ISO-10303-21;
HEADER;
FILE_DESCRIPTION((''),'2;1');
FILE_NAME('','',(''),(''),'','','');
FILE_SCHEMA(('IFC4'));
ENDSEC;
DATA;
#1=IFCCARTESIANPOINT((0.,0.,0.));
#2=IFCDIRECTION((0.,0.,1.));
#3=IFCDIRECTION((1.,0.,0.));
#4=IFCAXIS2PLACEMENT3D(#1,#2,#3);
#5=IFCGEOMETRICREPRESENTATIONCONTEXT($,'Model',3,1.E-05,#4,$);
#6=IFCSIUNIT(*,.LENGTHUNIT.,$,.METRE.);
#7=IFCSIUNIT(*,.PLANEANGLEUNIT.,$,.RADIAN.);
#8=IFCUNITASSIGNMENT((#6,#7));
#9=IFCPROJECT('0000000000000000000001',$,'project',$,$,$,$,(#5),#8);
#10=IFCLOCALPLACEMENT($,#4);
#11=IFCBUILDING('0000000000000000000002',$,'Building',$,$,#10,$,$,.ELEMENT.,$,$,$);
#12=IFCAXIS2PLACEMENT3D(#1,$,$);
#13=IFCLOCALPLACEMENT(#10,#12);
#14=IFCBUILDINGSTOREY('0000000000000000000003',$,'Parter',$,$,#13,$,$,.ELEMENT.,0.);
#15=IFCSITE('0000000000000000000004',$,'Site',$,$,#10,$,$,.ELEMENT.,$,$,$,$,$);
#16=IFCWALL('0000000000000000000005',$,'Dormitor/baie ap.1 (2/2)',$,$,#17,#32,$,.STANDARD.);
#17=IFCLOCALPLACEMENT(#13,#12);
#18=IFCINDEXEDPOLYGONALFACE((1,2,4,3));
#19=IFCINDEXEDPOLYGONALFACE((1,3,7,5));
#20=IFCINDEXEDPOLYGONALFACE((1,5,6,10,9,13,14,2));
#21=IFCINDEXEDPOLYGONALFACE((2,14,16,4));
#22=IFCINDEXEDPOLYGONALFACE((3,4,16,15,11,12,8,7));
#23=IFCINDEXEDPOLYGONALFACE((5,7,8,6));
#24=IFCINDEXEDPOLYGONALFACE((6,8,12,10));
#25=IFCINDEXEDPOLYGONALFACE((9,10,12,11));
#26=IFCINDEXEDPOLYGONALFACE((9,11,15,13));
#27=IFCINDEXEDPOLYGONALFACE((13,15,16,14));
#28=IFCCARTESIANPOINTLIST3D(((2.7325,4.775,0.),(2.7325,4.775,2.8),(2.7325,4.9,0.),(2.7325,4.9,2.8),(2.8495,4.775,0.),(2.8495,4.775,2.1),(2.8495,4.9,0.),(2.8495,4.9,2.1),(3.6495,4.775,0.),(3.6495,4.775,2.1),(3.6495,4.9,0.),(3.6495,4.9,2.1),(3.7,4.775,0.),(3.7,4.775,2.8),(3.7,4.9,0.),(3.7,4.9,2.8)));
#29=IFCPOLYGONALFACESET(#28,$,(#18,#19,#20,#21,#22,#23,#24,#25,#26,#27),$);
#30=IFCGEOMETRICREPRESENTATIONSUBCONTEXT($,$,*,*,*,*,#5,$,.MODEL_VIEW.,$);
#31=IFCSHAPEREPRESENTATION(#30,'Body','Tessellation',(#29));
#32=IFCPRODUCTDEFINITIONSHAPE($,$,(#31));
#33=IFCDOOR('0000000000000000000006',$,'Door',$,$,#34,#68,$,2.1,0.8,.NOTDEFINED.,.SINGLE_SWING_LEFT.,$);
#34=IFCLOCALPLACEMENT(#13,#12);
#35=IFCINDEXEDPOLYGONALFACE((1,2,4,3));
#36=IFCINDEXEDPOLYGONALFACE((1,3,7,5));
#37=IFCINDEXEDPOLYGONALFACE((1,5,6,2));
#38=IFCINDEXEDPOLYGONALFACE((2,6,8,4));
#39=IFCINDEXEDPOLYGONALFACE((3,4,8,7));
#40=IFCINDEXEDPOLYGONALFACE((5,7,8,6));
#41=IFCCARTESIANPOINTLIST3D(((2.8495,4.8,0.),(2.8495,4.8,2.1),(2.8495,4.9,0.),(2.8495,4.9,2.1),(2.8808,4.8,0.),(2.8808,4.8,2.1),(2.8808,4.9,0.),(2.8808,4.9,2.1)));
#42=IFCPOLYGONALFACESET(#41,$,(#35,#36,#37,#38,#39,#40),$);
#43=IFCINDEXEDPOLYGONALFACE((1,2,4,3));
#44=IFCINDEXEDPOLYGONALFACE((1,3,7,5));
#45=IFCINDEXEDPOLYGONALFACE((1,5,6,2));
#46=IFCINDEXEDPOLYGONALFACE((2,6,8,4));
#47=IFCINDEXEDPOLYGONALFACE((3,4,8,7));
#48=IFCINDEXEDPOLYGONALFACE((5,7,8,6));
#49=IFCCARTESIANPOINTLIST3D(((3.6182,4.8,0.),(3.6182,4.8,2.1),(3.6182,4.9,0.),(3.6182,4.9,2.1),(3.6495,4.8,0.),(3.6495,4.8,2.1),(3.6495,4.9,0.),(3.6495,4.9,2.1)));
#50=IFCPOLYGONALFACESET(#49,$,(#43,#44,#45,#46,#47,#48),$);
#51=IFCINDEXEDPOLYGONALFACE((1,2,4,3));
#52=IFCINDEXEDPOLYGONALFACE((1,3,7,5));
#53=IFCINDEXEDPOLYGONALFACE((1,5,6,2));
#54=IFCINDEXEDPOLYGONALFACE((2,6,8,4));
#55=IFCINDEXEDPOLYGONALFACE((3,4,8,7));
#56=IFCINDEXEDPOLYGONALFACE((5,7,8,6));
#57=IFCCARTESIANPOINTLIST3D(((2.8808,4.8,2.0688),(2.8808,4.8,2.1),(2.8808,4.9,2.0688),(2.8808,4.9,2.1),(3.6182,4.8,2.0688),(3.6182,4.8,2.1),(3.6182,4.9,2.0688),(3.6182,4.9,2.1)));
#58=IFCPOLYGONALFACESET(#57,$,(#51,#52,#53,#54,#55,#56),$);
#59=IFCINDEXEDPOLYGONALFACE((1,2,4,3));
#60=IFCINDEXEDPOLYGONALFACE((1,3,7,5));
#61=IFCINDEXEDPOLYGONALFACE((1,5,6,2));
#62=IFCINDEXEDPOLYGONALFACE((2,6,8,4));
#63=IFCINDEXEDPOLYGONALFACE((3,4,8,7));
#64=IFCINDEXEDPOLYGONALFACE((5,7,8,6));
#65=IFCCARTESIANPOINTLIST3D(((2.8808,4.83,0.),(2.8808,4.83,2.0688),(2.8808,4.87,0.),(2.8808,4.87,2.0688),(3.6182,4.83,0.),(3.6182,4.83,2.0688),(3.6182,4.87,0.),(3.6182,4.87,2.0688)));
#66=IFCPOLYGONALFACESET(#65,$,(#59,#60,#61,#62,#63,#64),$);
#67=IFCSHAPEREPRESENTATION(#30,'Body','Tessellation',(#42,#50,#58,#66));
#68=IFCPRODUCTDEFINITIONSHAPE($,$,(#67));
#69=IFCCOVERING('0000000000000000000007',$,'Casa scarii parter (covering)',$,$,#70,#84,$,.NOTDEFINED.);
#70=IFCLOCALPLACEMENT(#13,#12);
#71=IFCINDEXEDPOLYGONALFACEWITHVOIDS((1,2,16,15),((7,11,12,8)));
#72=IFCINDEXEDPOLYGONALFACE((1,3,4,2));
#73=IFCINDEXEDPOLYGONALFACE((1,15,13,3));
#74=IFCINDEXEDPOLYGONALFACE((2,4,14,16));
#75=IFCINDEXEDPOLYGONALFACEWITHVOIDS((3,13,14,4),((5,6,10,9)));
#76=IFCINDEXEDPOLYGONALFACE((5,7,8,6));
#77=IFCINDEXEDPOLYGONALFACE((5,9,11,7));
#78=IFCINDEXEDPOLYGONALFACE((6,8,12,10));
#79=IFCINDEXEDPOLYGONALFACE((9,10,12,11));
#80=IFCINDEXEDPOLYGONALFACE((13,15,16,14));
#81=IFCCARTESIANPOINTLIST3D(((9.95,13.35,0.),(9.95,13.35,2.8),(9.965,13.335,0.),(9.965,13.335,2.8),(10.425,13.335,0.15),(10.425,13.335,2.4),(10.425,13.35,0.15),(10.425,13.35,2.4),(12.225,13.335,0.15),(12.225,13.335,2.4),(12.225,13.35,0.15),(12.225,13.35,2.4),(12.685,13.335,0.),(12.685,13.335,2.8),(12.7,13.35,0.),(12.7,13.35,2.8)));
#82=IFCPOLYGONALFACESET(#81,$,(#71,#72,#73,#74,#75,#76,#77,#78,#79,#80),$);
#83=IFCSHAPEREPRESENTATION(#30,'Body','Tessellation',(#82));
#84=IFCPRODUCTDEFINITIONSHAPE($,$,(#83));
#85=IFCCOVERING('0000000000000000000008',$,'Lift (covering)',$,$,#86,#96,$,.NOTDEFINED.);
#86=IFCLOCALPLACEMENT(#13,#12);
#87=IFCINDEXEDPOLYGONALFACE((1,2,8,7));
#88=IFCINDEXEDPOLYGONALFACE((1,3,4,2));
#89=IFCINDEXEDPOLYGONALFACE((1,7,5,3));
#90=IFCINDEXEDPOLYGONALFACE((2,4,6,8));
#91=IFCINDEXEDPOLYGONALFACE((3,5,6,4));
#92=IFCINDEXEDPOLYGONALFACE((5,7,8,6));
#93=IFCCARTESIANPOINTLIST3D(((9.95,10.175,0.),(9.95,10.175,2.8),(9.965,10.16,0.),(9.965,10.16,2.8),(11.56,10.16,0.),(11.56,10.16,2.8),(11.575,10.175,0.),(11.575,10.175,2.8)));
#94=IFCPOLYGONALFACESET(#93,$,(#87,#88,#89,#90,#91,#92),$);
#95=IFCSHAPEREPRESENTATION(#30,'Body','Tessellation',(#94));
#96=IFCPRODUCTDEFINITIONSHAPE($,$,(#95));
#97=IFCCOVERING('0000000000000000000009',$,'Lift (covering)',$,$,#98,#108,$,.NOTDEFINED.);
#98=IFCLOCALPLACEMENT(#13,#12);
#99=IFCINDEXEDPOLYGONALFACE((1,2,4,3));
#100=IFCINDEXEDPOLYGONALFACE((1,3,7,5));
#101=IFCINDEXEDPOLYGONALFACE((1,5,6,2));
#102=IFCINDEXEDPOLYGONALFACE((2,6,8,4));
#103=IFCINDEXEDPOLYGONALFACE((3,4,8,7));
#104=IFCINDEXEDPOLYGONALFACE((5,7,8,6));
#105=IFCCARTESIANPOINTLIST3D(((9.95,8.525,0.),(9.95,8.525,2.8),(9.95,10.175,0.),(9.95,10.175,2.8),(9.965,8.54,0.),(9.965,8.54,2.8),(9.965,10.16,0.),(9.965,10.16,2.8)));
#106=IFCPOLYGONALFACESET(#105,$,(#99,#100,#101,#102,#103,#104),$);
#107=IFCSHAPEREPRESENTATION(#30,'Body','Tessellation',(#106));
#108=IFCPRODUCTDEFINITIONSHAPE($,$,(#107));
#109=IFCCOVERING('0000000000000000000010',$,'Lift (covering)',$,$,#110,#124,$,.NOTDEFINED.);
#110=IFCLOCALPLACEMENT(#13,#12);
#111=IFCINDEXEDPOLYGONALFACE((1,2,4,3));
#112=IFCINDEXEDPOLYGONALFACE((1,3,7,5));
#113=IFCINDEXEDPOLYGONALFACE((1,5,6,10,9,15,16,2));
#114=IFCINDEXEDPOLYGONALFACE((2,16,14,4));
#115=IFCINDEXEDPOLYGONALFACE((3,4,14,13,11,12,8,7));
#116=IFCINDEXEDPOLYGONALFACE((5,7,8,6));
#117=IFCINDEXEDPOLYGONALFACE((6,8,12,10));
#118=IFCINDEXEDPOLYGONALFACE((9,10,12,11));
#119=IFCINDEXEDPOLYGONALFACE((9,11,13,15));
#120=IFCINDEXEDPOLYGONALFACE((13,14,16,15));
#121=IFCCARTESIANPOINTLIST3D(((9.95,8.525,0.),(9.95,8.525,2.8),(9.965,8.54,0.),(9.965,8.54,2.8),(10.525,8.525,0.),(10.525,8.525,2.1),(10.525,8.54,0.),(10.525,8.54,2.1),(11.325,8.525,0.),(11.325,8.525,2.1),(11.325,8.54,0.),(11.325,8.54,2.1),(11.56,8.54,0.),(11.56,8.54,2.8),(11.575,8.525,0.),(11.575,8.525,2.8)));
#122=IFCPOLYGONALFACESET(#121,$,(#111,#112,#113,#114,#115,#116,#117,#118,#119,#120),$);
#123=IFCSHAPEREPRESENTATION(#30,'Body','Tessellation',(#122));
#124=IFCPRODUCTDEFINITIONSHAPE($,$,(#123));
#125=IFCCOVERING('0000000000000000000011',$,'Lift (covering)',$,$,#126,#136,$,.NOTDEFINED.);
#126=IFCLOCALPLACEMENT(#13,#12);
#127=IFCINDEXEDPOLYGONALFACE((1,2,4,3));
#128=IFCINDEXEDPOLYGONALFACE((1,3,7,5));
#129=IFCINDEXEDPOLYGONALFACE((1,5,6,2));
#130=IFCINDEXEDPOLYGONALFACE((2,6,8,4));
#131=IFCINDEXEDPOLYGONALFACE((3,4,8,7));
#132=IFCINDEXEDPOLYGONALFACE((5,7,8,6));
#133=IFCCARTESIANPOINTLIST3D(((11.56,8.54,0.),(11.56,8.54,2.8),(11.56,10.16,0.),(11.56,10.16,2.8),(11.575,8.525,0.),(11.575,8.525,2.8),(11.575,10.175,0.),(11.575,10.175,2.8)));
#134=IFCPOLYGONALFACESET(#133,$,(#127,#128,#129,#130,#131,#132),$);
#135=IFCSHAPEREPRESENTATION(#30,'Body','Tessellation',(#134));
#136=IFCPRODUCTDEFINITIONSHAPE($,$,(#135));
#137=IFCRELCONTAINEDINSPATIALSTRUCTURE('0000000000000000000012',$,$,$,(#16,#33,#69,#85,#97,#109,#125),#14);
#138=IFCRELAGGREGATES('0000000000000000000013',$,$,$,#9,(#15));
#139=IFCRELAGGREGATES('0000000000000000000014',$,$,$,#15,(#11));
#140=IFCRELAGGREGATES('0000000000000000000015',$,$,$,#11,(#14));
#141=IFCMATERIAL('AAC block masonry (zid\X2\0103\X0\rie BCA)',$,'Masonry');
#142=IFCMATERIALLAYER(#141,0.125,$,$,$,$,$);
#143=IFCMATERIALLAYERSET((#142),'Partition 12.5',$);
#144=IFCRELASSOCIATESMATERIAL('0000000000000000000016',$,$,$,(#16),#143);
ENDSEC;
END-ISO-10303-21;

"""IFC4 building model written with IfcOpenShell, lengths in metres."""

from ifc_helpers import new_model, si_unit, frame, frame_2d, origin, origin_with_axes, origin_2d, place, context, subcontext, project, spatial, polyline, rectangle, outline, extrude, material, layer, layer_set, layer_usage, element, fill, save


model = new_model("IFC4")

# Units and contexts
model_context = context("Model", 3, precision=1e-05, world=origin_with_axes())
sub_context = subcontext(model_context, None, None, "MODEL_VIEW")
ifc_project = project(units=[si_unit("LENGTHUNIT", "METRE"), si_unit("PLANEANGLEUNIT", "RADIAN")], contexts=[model_context])

# Site, building, storey
placement = place(None, origin_with_axes())
site = spatial("IfcSite", under=ifc_project, at=placement, Name="Site", CompositionType="ELEMENT")
building = spatial("IfcBuilding", under=site, at=placement, Name="Building", CompositionType="ELEMENT")
storey_placement = place(placement, origin())
storey = spatial("IfcBuildingStorey", under=building, at=storey_placement, Name="Parter", CompositionType="ELEMENT", Elevation=0.0)

# Shared definitions
ifc_material_1 = material(Name="AAC block masonry (zidărie BCA)", Category="Masonry")
ifc_layer_1 = layer(ifc_material_1, 0.125)
ifc_layer_set_1 = layer_set([ifc_layer_1], Name="Partition 12.5")
ifc_layer_usage_1 = layer_usage(ifc_layer_set_1, "AXIS2", "POSITIVE", -0.0625)

# Wall, opening, door
wall_1_placement = place(storey_placement, frame((2.7325, 4.8375, 0.0), x_axis=(1.0, 0.0, 0.0)))
wall_1 = element("IfcWall", 1, at=wall_1_placement, inside=storey, material=ifc_layer_usage_1, Name="Dormitor/baie ap.1 (2/2)", PredefinedType="STANDARD", context=sub_context, shape_type="SweptSolid", body=[
    extrude(rectangle(XDim=0.9675, YDim=0.125, at=frame_2d((0.4838, 0.0))), origin(), (0.0, 0.0, 1.0), 2.8),
])
opening_1_placement = place(wall_1_placement, frame((0.517, 0.1125, 0.0), z_axis=(0.0, -1.0, 0.0), x_axis=(1.0, 0.0, 0.0)))
opening_1 = element("IfcOpeningElement", 2, at=opening_1_placement, cuts=wall_1, PredefinedType="OPENING", context=sub_context, shape_type="SweptSolid", body=[
    extrude(rectangle(XDim=0.8, YDim=2.1, at=frame_2d((0.0, 1.05))), origin(), (0.0, 0.0, 1.0), 0.225),
])
door_placement = place(wall_1_placement, frame((0.517, 0.0625, 0.0), z_axis=(0.0, -1.0, 0.0), x_axis=(1.0, 0.0, 0.0)))
door = element("IfcDoor", 3, at=door_placement, inside=storey, Name="Door", OperationType="SINGLE_SWING_LEFT", OverallHeight=2.1, OverallWidth=0.8, PredefinedType="NOTDEFINED", context=sub_context, shape_type="SweptSolid", body=[
    extrude(rectangle(XDim=0.0312, YDim=2.1, at=origin_2d()), frame((-0.3844, 1.05, 0.0)), (0.0, 0.0, 1.0), 0.1),
    extrude(rectangle(XDim=0.0312, YDim=2.1, at=origin_2d()), frame((0.3844, 1.05, 0.0)), (0.0, 0.0, 1.0), 0.1),
    extrude(rectangle(XDim=0.7375, YDim=0.0312, at=origin_2d()), frame((0.0, 2.0844, 0.0)), (0.0, 0.0, 1.0), 0.1),
    extrude(rectangle(XDim=0.7375, YDim=2.0688, at=origin_2d()), frame((0.0, 1.0344, 0.03)), (0.0, 0.0, 1.0), 0.04),
])
fill(opening_1, door)

# Covering, opening
covering_1_placement = place(storey_placement, origin_with_axes())
covering_1 = element("IfcCovering", 4, at=covering_1_placement, inside=storey, Name="Casa scarii parter (covering)", PredefinedType="NOTDEFINED", context=sub_context, shape_type="SweptSolid", body=[
    extrude(outline(polyline([(12.7, 13.35), (9.95, 13.35), (9.965, 13.335), (12.685, 13.335), (12.7, 13.35)])), origin(), (0.0, 0.0, 1.0), 2.8),
])
opening_2_placement = place(covering_1_placement, frame((11.325, 13.665, 0.15), z_axis=(0.0, -1.0, 0.0), x_axis=(1.0, 0.0, 0.0)))
element("IfcOpeningElement", 5, at=opening_2_placement, cuts=covering_1, PredefinedType="OPENING", context=sub_context, shape_type="SweptSolid", body=[
    extrude(rectangle(XDim=1.8, YDim=2.25, at=origin_2d()), frame((0.0, 1.125, 0.0)), (0.0, 0.0, 1.0), 0.38),
])

# Coverings
covering_2_placement = place(storey_placement, origin_with_axes())
element("IfcCovering", 6, at=covering_2_placement, inside=storey, Name="Lift (covering)", PredefinedType="NOTDEFINED", context=sub_context, shape_type="SweptSolid", body=[
    extrude(outline(polyline([(11.575, 10.175), (9.95, 10.175), (9.965, 10.16), (11.56, 10.16), (11.575, 10.175)])), origin(), (0.0, 0.0, 1.0), 2.8),
])
covering_3_placement = place(storey_placement, origin_with_axes())
element("IfcCovering", 7, at=covering_3_placement, inside=storey, Name="Lift (covering)", PredefinedType="NOTDEFINED", context=sub_context, shape_type="SweptSolid", body=[
    extrude(outline(polyline([(9.95, 10.175), (9.95, 8.525), (9.965, 8.54), (9.965, 10.16), (9.95, 10.175)])), origin(), (0.0, 0.0, 1.0), 2.8),
])

# Covering, opening
covering_4_placement = place(storey_placement, origin_with_axes())
covering_4 = element("IfcCovering", 8, at=covering_4_placement, inside=storey, Name="Lift (covering)", PredefinedType="NOTDEFINED", context=sub_context, shape_type="SweptSolid", body=[
    extrude(outline(polyline([(9.95, 8.525), (11.575, 8.525), (11.56, 8.54), (9.965, 8.54), (9.95, 8.525)])), origin(), (0.0, 0.0, 1.0), 2.8),
])
opening_3_placement = place(covering_4_placement, frame((10.925, 8.59, 0.0), z_axis=(0.0, -1.0, 0.0), x_axis=(1.0, 0.0, 0.0)))
element("IfcOpeningElement", 9, at=opening_3_placement, cuts=covering_4, PredefinedType="OPENING", context=sub_context, shape_type="SweptSolid", body=[
    extrude(rectangle(XDim=0.8, YDim=2.1, at=origin_2d()), frame((0.0, 1.05, 0.0)), (0.0, 0.0, 1.0), 0.38),
])

# Covering
covering_5_placement = place(storey_placement, origin_with_axes())
element("IfcCovering", 10, at=covering_5_placement, inside=storey, Name="Lift (covering)", PredefinedType="NOTDEFINED", context=sub_context, shape_type="SweptSolid", body=[
    extrude(outline(polyline([(11.575, 8.525), (11.575, 10.175), (11.56, 10.16), (11.56, 8.54), (11.575, 8.525)])), origin(), (0.0, 0.0, 1.0), 2.8),
])

save(model, "model.ifc")
